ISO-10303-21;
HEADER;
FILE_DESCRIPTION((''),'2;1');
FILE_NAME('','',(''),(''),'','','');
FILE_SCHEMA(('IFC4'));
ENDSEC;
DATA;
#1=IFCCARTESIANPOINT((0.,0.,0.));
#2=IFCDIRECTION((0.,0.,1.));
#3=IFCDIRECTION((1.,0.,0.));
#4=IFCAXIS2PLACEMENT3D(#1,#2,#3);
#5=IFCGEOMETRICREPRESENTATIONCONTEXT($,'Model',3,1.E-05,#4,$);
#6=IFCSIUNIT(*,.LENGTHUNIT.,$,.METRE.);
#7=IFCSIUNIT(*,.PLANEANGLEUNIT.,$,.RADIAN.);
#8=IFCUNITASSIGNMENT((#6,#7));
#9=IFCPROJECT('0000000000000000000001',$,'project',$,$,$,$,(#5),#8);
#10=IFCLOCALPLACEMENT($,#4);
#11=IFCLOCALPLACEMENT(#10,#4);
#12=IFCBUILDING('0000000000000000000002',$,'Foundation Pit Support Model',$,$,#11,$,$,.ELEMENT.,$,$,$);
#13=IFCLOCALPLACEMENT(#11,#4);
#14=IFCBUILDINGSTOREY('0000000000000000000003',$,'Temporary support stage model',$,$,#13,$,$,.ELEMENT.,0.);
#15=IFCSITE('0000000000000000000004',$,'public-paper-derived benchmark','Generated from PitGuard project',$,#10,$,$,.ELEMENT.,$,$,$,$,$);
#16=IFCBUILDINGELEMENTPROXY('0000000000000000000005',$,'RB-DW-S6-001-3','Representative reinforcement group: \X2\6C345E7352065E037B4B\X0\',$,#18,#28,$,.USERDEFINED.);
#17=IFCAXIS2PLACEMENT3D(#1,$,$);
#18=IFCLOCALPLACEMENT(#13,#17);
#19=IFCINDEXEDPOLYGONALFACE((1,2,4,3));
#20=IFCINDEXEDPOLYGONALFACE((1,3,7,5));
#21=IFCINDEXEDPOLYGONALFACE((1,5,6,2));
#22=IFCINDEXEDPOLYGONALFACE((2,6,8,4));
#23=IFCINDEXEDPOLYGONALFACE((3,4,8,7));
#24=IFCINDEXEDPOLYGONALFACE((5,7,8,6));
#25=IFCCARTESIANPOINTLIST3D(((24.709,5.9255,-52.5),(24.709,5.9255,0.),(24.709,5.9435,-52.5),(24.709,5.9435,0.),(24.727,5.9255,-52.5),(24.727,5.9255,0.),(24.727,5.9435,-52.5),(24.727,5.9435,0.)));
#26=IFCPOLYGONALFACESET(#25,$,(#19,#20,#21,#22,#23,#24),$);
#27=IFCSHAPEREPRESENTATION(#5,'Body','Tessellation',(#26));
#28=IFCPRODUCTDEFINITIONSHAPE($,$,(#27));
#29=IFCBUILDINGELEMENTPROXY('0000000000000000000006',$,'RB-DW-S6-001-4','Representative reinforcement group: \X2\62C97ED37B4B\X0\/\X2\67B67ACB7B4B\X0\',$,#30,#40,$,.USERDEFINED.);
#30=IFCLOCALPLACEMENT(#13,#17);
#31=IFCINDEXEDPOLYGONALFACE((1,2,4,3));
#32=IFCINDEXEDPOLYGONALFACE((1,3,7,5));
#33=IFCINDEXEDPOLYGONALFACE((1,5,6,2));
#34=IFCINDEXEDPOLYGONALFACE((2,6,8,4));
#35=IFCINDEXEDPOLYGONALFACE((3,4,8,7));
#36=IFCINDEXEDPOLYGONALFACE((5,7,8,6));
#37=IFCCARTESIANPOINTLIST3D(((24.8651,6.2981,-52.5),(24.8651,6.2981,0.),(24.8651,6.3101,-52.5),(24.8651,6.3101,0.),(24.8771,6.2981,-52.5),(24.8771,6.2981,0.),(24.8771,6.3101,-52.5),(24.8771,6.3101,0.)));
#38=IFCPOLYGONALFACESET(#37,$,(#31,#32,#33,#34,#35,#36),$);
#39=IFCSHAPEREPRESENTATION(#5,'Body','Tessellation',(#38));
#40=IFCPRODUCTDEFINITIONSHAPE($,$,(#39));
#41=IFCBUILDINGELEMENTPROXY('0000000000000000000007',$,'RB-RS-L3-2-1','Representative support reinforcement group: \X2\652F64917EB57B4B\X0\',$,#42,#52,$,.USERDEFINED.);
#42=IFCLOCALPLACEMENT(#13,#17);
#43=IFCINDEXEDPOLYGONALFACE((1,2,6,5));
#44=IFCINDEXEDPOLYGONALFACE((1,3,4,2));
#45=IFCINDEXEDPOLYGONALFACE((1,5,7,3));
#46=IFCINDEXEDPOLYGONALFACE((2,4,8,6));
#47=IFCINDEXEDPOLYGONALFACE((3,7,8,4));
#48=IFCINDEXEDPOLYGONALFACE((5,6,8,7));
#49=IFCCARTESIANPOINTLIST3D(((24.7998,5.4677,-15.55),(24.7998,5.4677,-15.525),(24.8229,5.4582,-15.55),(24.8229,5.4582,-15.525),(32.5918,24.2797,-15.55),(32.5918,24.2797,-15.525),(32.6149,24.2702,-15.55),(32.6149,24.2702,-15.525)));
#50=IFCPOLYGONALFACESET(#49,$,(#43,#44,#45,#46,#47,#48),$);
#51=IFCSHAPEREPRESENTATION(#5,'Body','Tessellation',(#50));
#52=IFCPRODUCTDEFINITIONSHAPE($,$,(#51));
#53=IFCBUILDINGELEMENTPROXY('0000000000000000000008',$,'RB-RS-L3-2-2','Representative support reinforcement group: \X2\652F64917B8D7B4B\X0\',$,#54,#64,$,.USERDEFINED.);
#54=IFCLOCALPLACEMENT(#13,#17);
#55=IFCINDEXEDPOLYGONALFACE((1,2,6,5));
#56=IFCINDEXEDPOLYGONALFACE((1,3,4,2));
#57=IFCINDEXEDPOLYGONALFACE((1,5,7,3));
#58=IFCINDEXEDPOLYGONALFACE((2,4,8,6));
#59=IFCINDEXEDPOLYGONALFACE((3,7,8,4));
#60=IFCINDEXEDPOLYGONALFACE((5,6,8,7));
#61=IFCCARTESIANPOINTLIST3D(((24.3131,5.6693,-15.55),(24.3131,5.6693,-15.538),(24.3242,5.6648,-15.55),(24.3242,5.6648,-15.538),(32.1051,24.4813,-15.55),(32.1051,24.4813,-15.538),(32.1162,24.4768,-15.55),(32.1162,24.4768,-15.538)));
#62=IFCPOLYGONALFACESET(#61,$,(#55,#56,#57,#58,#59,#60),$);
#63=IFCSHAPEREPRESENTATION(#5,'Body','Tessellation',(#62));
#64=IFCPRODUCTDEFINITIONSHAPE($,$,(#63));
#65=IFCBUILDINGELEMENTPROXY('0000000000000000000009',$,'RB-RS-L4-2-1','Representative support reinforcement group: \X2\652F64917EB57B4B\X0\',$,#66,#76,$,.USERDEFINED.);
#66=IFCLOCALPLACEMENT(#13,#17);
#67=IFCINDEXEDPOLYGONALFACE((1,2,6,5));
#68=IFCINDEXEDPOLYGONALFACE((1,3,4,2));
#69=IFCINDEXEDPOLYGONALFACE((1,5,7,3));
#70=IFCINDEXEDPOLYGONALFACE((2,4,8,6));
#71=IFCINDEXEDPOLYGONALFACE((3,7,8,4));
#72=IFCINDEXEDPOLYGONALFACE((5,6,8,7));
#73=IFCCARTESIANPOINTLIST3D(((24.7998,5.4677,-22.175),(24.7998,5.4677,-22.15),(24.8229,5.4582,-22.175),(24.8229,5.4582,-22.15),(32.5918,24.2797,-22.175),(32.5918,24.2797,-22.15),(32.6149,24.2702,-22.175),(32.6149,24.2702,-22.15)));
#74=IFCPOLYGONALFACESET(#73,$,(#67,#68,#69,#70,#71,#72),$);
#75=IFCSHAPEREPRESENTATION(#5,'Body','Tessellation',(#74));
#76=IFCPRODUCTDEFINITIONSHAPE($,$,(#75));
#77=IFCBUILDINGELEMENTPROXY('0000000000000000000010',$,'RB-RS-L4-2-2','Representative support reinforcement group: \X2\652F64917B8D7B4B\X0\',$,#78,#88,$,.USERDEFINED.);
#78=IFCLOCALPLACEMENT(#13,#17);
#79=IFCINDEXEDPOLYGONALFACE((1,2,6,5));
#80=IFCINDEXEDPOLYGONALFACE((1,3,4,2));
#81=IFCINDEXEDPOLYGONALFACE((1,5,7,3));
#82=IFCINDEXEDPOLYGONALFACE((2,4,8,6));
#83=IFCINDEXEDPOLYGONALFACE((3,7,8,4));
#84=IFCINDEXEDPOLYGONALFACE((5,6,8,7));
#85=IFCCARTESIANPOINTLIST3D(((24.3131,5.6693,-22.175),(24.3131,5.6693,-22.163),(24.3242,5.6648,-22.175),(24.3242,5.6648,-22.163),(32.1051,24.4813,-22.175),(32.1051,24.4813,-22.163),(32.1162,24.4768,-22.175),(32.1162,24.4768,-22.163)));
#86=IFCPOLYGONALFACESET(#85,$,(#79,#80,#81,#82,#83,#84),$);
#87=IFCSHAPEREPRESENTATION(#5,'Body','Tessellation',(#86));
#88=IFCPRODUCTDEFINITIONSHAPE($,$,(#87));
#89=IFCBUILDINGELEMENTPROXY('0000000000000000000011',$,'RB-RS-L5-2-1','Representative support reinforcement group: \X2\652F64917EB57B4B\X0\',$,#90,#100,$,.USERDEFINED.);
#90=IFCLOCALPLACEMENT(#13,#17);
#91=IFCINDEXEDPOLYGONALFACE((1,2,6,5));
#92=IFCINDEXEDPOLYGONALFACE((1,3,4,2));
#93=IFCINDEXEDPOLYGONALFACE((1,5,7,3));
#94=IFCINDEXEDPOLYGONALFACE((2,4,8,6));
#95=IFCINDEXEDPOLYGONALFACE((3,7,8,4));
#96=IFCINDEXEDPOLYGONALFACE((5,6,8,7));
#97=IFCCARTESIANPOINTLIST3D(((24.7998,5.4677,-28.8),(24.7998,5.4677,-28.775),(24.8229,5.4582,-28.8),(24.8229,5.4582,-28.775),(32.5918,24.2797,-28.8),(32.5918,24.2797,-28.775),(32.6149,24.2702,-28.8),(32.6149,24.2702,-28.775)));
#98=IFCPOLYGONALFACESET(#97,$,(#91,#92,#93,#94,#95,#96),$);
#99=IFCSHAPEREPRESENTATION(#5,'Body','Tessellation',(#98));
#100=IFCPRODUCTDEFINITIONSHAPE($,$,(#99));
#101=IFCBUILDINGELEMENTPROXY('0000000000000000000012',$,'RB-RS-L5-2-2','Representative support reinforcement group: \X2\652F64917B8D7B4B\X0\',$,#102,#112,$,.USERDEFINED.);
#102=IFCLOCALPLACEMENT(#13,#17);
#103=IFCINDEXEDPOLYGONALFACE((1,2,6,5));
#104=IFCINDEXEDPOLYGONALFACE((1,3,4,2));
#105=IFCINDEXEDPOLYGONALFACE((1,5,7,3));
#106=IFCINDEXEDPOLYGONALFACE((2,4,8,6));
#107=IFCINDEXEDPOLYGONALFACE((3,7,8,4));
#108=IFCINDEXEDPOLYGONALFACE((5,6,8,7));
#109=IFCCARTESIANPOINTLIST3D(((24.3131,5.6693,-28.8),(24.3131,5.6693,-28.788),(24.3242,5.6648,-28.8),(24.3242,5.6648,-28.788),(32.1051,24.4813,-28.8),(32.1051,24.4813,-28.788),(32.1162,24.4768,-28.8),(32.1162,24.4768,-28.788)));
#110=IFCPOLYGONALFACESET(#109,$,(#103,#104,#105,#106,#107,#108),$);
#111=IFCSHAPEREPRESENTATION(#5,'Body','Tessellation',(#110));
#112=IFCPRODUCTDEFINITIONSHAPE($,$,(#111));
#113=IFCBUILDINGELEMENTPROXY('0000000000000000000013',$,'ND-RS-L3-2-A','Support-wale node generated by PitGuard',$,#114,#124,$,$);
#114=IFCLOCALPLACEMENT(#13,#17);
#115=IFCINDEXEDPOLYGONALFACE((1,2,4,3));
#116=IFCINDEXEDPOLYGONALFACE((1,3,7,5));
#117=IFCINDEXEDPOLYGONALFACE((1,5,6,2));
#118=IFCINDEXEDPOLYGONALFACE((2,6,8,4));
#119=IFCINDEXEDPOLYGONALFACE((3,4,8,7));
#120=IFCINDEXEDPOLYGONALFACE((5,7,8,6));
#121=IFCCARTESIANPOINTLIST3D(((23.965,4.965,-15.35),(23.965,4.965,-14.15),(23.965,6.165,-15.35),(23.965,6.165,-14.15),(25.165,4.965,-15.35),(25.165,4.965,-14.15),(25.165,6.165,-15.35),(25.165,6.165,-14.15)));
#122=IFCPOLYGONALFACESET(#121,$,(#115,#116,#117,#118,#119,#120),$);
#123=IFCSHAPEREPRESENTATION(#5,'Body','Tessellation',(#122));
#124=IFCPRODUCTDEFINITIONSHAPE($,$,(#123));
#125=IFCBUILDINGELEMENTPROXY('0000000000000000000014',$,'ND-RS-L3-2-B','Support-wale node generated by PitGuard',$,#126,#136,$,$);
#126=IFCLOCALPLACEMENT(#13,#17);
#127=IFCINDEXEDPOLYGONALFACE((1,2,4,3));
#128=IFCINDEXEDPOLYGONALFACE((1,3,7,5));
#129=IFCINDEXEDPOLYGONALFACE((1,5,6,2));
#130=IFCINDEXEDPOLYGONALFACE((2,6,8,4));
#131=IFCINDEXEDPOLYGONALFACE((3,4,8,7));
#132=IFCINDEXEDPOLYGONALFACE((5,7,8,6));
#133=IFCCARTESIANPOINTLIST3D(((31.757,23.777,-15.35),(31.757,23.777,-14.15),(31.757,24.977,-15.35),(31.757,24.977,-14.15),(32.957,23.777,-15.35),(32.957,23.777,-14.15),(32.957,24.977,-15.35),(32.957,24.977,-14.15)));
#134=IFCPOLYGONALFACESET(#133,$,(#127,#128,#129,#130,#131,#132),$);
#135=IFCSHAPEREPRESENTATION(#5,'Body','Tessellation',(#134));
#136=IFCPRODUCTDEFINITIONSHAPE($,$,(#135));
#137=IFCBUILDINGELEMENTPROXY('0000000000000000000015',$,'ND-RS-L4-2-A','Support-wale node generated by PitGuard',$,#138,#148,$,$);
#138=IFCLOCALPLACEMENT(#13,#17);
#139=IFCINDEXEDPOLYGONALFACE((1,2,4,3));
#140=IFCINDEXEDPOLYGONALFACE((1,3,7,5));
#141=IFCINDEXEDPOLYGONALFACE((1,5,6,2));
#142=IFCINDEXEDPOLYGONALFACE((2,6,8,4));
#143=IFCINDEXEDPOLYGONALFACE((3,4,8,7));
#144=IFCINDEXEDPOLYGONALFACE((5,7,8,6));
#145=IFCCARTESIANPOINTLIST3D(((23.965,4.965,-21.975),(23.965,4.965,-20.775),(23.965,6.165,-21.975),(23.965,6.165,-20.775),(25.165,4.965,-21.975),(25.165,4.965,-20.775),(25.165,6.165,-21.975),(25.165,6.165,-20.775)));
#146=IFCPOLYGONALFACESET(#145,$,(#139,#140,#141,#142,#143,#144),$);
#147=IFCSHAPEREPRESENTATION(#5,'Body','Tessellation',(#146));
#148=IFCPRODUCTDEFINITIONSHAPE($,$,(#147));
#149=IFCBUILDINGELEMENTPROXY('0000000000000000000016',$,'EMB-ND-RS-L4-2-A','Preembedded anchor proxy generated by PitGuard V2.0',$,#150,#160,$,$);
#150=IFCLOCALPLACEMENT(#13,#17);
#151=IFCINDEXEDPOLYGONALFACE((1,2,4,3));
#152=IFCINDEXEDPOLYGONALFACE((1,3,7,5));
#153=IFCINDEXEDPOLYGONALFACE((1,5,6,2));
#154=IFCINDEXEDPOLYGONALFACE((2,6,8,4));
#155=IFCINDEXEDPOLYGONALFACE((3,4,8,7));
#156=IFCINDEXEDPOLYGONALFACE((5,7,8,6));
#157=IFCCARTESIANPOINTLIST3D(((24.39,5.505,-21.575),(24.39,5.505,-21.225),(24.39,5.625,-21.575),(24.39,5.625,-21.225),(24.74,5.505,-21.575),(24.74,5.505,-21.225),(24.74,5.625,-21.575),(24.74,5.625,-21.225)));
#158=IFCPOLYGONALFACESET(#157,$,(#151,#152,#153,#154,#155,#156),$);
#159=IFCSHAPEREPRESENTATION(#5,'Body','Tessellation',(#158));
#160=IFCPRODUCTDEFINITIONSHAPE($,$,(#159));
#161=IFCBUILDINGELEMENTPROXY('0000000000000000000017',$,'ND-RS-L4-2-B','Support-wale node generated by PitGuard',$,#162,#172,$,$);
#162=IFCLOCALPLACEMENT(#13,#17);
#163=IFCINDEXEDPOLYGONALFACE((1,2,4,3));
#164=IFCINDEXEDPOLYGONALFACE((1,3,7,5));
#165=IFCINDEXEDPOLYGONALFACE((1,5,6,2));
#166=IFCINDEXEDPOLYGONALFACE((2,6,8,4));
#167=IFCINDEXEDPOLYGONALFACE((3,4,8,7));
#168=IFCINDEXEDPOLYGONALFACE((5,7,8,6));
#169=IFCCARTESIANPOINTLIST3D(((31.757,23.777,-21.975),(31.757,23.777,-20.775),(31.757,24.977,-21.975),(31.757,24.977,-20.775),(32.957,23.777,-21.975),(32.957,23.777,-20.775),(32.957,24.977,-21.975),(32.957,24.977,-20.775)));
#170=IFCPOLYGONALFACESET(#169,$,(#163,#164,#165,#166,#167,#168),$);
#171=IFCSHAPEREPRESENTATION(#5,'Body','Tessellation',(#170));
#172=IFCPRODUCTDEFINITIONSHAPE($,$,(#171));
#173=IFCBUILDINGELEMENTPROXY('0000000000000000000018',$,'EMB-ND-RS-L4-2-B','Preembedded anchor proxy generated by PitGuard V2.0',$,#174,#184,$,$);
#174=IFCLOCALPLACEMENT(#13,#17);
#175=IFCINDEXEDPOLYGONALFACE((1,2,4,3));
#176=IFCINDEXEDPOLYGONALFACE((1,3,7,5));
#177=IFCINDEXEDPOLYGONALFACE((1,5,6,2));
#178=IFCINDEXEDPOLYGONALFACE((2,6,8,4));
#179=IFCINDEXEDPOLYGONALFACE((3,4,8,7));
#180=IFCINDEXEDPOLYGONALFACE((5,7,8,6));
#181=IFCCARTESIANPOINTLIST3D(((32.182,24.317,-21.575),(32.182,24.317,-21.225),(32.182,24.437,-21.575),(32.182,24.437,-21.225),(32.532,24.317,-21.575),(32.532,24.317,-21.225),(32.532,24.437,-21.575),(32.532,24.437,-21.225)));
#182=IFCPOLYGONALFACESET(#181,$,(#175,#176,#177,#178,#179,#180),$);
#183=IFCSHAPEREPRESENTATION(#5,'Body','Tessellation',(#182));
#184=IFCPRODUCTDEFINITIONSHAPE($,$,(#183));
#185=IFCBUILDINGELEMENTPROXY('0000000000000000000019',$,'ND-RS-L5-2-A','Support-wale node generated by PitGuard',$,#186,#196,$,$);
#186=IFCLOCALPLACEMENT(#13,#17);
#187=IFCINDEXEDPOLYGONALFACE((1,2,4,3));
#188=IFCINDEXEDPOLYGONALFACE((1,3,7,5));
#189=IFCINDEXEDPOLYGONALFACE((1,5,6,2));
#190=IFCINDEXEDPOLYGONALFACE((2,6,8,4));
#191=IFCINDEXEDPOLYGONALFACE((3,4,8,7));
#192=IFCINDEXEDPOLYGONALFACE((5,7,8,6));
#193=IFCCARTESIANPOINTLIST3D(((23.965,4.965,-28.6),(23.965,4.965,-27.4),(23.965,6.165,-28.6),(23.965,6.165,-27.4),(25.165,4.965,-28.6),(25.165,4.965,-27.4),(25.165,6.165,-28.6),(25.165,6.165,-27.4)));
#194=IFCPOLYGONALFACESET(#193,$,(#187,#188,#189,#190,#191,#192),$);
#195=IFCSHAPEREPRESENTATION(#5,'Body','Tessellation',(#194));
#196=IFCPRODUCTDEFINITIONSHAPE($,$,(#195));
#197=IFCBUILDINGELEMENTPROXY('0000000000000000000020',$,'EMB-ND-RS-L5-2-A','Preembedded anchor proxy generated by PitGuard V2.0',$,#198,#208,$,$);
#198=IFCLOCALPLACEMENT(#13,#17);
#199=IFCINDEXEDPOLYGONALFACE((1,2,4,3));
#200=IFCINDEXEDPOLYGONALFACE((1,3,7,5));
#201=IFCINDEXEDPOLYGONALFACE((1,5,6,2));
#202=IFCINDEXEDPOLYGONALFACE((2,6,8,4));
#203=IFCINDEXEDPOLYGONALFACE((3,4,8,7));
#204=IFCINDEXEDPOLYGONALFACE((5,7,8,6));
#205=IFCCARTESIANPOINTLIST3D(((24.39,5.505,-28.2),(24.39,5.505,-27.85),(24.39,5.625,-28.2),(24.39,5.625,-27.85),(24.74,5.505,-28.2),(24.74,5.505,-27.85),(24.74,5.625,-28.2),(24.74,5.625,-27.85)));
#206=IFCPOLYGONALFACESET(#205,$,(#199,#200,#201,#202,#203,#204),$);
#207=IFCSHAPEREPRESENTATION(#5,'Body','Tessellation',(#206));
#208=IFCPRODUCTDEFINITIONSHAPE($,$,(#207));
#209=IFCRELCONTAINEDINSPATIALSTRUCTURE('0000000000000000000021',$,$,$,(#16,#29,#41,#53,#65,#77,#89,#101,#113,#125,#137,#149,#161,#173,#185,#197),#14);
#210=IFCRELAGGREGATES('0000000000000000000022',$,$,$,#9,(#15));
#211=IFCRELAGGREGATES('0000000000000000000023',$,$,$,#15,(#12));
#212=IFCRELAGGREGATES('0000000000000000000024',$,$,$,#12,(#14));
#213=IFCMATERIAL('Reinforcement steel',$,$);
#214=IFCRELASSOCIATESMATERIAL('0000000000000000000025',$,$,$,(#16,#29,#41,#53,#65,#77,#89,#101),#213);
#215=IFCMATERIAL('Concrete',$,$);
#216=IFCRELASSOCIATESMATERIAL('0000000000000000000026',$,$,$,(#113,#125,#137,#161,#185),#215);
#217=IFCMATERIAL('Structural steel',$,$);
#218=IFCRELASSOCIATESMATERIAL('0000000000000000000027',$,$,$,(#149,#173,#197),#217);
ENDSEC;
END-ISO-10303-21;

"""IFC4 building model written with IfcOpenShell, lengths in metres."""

from ifc_helpers import new_model, si_unit, frame, origin_with_axes, origin_2d, place, context, project, spatial, rectangle, extrude, material, element, save


model = new_model("IFC4")

# Units and contexts
model_context = context("Model", 3, precision=1e-05, world=origin_with_axes())
ifc_project = project(units=[si_unit("LENGTHUNIT", "METRE"), si_unit("PLANEANGLEUNIT", "RADIAN")], contexts=[model_context])

# Site, building, storey
site_placement = place(None, origin_with_axes())
site = spatial("IfcSite", under=ifc_project, at=site_placement, Name="public-paper-derived benchmark", Description="Generated from PitGuard project", CompositionType="ELEMENT")
building_placement = place(site_placement, origin_with_axes())
building = spatial("IfcBuilding", under=site, at=building_placement, Name="Foundation Pit Support Model", CompositionType="ELEMENT")
storey_placement = place(building_placement, origin_with_axes())
storey = spatial("IfcBuildingStorey", under=building, at=storey_placement, Name="Temporary support stage model", CompositionType="ELEMENT", Elevation=0.0)

# Shared definitions
ifc_material_1 = material(Name="Structural steel")

# Shared definitions
ifc_material_2 = material(Name="Concrete")

# Building element proxies
ifc_material_3 = material(Name="Reinforcement steel")
proxy_1_placement = place(storey_placement, frame((24.718, 5.9345, -52.5), z_axis=(0.0, 0.0, 1.0), x_axis=(1.0, 0.0, 0.0)))
element("IfcBuildingElementProxy", 1, at=proxy_1_placement, inside=storey, material=ifc_material_3, Name="RB-DW-S6-001-3", Description="Representative reinforcement group: 水平分布筋", PredefinedType="USERDEFINED", context=model_context, shape_type="SweptSolid", body=[
    extrude(rectangle(XDim=0.018, YDim=0.018, at=origin_2d()), origin_with_axes(), (0.0, 0.0, 1.0), 52.5),
])
proxy_2_placement = place(storey_placement, frame((24.8711, 6.3041, -52.5), z_axis=(0.0, 0.0, 1.0), x_axis=(1.0, 0.0, 0.0)))
element("IfcBuildingElementProxy", 2, at=proxy_2_placement, inside=storey, material=ifc_material_3, Name="RB-DW-S6-001-4", Description="Representative reinforcement group: 拉结筋/架立筋", PredefinedType="USERDEFINED", context=model_context, shape_type="SweptSolid", body=[
    extrude(rectangle(XDim=0.012, YDim=0.012, at=origin_2d()), origin_with_axes(), (0.0, 0.0, 1.0), 52.5),
])
proxy_3_placement = place(storey_placement, frame((28.7074, 14.869, -15.55), z_axis=(0.0, 0.0, 1.0), x_axis=(0.382676, 0.923883, 0.0)))
element("IfcBuildingElementProxy", 3, at=proxy_3_placement, inside=storey, material=ifc_material_3, Name="RB-RS-L3-2-1", Description="Representative support reinforcement group: 支撑纵筋", PredefinedType="USERDEFINED", context=model_context, shape_type="SweptSolid", body=[
    extrude(rectangle(XDim=20.3619, YDim=0.025, at=origin_2d()), origin_with_axes(), (0.0, 0.0, 1.0), 0.025),
])
proxy_4_placement = place(storey_placement, frame((28.2146, 15.073, -15.55), z_axis=(0.0, 0.0, 1.0), x_axis=(0.382676, 0.923883, 0.0)))
element("IfcBuildingElementProxy", 4, at=proxy_4_placement, inside=storey, material=ifc_material_3, Name="RB-RS-L3-2-2", Description="Representative support reinforcement group: 支撑箍筋", PredefinedType="USERDEFINED", context=model_context, shape_type="SweptSolid", body=[
    extrude(rectangle(XDim=20.3619, YDim=0.012, at=origin_2d()), origin_with_axes(), (0.0, 0.0, 1.0), 0.012),
])
proxy_5_placement = place(storey_placement, frame((28.7074, 14.869, -22.175), z_axis=(0.0, 0.0, 1.0), x_axis=(0.382676, 0.923883, 0.0)))
element("IfcBuildingElementProxy", 5, at=proxy_5_placement, inside=storey, material=ifc_material_3, Name="RB-RS-L4-2-1", Description="Representative support reinforcement group: 支撑纵筋", PredefinedType="USERDEFINED", context=model_context, shape_type="SweptSolid", body=[
    extrude(rectangle(XDim=20.3619, YDim=0.025, at=origin_2d()), origin_with_axes(), (0.0, 0.0, 1.0), 0.025),
])
proxy_6_placement = place(storey_placement, frame((28.2146, 15.073, -22.175), z_axis=(0.0, 0.0, 1.0), x_axis=(0.382676, 0.923883, 0.0)))
element("IfcBuildingElementProxy", 6, at=proxy_6_placement, inside=storey, material=ifc_material_3, Name="RB-RS-L4-2-2", Description="Representative support reinforcement group: 支撑箍筋", PredefinedType="USERDEFINED", context=model_context, shape_type="SweptSolid", body=[
    extrude(rectangle(XDim=20.3619, YDim=0.012, at=origin_2d()), origin_with_axes(), (0.0, 0.0, 1.0), 0.012),
])
proxy_7_placement = place(storey_placement, frame((28.7074, 14.869, -28.8), z_axis=(0.0, 0.0, 1.0), x_axis=(0.382676, 0.923883, 0.0)))
element("IfcBuildingElementProxy", 7, at=proxy_7_placement, inside=storey, material=ifc_material_3, Name="RB-RS-L5-2-1", Description="Representative support reinforcement group: 支撑纵筋", PredefinedType="USERDEFINED", context=model_context, shape_type="SweptSolid", body=[
    extrude(rectangle(XDim=20.3619, YDim=0.025, at=origin_2d()), origin_with_axes(), (0.0, 0.0, 1.0), 0.025),
])
proxy_8_placement = place(storey_placement, frame((28.2146, 15.073, -28.8), z_axis=(0.0, 0.0, 1.0), x_axis=(0.382676, 0.923883, 0.0)))
element("IfcBuildingElementProxy", 8, at=proxy_8_placement, inside=storey, material=ifc_material_3, Name="RB-RS-L5-2-2", Description="Representative support reinforcement group: 支撑箍筋", PredefinedType="USERDEFINED", context=model_context, shape_type="SweptSolid", body=[
    extrude(rectangle(XDim=20.3619, YDim=0.012, at=origin_2d()), origin_with_axes(), (0.0, 0.0, 1.0), 0.012),
])
for number, where, z_axis, x_axis, name in (
    (9, (24.565, 5.565, -15.35), (0.0, 0.0, 1.0), (1.0, 0.0, 0.0), "ND-RS-L3-2-A"),
    (10, (32.357, 24.377, -15.35), (0.0, 0.0, 1.0), (1.0, 0.0, 0.0), "ND-RS-L3-2-B"),
    (11, (24.565, 5.565, -21.975), (0.0, 0.0, 1.0), (1.0, 0.0, 0.0), "ND-RS-L4-2-A"),
):
    element("IfcBuildingElementProxy", number, at=place(storey_placement, frame(where, z_axis=z_axis, x_axis=x_axis)), inside=storey, material=ifc_material_2, Name=name, Description="Support-wale node generated by PitGuard", context=model_context, shape_type="SweptSolid", body=[
        extrude(rectangle(XDim=1.2, YDim=1.2, at=origin_2d()), origin_with_axes(), (0.0, 0.0, 1.0), 1.2),
    ])
proxy_9_placement = place(storey_placement, frame((24.565, 5.565, -21.575), z_axis=(0.0, 0.0, 1.0), x_axis=(1.0, 0.0, 0.0)))
element("IfcBuildingElementProxy", 12, at=proxy_9_placement, inside=storey, material=ifc_material_1, Name="EMB-ND-RS-L4-2-A", Description="Preembedded anchor proxy generated by PitGuard V2.0", context=model_context, shape_type="SweptSolid", body=[
    extrude(rectangle(XDim=0.35, YDim=0.12, at=origin_2d()), origin_with_axes(), (0.0, 0.0, 1.0), 0.35),
])
proxy_10_placement = place(storey_placement, frame((32.357, 24.377, -21.975), z_axis=(0.0, 0.0, 1.0), x_axis=(1.0, 0.0, 0.0)))
element("IfcBuildingElementProxy", 13, at=proxy_10_placement, inside=storey, material=ifc_material_2, Name="ND-RS-L4-2-B", Description="Support-wale node generated by PitGuard", context=model_context, shape_type="SweptSolid", body=[
    extrude(rectangle(XDim=1.2, YDim=1.2, at=origin_2d()), origin_with_axes(), (0.0, 0.0, 1.0), 1.2),
])
proxy_11_placement = place(storey_placement, frame((32.357, 24.377, -21.575), z_axis=(0.0, 0.0, 1.0), x_axis=(1.0, 0.0, 0.0)))
element("IfcBuildingElementProxy", 14, at=proxy_11_placement, inside=storey, material=ifc_material_1, Name="EMB-ND-RS-L4-2-B", Description="Preembedded anchor proxy generated by PitGuard V2.0", context=model_context, shape_type="SweptSolid", body=[
    extrude(rectangle(XDim=0.35, YDim=0.12, at=origin_2d()), origin_with_axes(), (0.0, 0.0, 1.0), 0.35),
])
proxy_12_placement = place(storey_placement, frame((24.565, 5.565, -28.6), z_axis=(0.0, 0.0, 1.0), x_axis=(1.0, 0.0, 0.0)))
element("IfcBuildingElementProxy", 15, at=proxy_12_placement, inside=storey, material=ifc_material_2, Name="ND-RS-L5-2-A", Description="Support-wale node generated by PitGuard", context=model_context, shape_type="SweptSolid", body=[
    extrude(rectangle(XDim=1.2, YDim=1.2, at=origin_2d()), origin_with_axes(), (0.0, 0.0, 1.0), 1.2),
])
proxy_13_placement = place(storey_placement, frame((24.565, 5.565, -28.2), z_axis=(0.0, 0.0, 1.0), x_axis=(1.0, 0.0, 0.0)))
element("IfcBuildingElementProxy", 16, at=proxy_13_placement, inside=storey, material=ifc_material_1, Name="EMB-ND-RS-L5-2-A", Description="Preembedded anchor proxy generated by PitGuard V2.0", context=model_context, shape_type="SweptSolid", body=[
    extrude(rectangle(XDim=0.35, YDim=0.12, at=origin_2d()), origin_with_axes(), (0.0, 0.0, 1.0), 0.35),
])

save(model, "model.ifc")
